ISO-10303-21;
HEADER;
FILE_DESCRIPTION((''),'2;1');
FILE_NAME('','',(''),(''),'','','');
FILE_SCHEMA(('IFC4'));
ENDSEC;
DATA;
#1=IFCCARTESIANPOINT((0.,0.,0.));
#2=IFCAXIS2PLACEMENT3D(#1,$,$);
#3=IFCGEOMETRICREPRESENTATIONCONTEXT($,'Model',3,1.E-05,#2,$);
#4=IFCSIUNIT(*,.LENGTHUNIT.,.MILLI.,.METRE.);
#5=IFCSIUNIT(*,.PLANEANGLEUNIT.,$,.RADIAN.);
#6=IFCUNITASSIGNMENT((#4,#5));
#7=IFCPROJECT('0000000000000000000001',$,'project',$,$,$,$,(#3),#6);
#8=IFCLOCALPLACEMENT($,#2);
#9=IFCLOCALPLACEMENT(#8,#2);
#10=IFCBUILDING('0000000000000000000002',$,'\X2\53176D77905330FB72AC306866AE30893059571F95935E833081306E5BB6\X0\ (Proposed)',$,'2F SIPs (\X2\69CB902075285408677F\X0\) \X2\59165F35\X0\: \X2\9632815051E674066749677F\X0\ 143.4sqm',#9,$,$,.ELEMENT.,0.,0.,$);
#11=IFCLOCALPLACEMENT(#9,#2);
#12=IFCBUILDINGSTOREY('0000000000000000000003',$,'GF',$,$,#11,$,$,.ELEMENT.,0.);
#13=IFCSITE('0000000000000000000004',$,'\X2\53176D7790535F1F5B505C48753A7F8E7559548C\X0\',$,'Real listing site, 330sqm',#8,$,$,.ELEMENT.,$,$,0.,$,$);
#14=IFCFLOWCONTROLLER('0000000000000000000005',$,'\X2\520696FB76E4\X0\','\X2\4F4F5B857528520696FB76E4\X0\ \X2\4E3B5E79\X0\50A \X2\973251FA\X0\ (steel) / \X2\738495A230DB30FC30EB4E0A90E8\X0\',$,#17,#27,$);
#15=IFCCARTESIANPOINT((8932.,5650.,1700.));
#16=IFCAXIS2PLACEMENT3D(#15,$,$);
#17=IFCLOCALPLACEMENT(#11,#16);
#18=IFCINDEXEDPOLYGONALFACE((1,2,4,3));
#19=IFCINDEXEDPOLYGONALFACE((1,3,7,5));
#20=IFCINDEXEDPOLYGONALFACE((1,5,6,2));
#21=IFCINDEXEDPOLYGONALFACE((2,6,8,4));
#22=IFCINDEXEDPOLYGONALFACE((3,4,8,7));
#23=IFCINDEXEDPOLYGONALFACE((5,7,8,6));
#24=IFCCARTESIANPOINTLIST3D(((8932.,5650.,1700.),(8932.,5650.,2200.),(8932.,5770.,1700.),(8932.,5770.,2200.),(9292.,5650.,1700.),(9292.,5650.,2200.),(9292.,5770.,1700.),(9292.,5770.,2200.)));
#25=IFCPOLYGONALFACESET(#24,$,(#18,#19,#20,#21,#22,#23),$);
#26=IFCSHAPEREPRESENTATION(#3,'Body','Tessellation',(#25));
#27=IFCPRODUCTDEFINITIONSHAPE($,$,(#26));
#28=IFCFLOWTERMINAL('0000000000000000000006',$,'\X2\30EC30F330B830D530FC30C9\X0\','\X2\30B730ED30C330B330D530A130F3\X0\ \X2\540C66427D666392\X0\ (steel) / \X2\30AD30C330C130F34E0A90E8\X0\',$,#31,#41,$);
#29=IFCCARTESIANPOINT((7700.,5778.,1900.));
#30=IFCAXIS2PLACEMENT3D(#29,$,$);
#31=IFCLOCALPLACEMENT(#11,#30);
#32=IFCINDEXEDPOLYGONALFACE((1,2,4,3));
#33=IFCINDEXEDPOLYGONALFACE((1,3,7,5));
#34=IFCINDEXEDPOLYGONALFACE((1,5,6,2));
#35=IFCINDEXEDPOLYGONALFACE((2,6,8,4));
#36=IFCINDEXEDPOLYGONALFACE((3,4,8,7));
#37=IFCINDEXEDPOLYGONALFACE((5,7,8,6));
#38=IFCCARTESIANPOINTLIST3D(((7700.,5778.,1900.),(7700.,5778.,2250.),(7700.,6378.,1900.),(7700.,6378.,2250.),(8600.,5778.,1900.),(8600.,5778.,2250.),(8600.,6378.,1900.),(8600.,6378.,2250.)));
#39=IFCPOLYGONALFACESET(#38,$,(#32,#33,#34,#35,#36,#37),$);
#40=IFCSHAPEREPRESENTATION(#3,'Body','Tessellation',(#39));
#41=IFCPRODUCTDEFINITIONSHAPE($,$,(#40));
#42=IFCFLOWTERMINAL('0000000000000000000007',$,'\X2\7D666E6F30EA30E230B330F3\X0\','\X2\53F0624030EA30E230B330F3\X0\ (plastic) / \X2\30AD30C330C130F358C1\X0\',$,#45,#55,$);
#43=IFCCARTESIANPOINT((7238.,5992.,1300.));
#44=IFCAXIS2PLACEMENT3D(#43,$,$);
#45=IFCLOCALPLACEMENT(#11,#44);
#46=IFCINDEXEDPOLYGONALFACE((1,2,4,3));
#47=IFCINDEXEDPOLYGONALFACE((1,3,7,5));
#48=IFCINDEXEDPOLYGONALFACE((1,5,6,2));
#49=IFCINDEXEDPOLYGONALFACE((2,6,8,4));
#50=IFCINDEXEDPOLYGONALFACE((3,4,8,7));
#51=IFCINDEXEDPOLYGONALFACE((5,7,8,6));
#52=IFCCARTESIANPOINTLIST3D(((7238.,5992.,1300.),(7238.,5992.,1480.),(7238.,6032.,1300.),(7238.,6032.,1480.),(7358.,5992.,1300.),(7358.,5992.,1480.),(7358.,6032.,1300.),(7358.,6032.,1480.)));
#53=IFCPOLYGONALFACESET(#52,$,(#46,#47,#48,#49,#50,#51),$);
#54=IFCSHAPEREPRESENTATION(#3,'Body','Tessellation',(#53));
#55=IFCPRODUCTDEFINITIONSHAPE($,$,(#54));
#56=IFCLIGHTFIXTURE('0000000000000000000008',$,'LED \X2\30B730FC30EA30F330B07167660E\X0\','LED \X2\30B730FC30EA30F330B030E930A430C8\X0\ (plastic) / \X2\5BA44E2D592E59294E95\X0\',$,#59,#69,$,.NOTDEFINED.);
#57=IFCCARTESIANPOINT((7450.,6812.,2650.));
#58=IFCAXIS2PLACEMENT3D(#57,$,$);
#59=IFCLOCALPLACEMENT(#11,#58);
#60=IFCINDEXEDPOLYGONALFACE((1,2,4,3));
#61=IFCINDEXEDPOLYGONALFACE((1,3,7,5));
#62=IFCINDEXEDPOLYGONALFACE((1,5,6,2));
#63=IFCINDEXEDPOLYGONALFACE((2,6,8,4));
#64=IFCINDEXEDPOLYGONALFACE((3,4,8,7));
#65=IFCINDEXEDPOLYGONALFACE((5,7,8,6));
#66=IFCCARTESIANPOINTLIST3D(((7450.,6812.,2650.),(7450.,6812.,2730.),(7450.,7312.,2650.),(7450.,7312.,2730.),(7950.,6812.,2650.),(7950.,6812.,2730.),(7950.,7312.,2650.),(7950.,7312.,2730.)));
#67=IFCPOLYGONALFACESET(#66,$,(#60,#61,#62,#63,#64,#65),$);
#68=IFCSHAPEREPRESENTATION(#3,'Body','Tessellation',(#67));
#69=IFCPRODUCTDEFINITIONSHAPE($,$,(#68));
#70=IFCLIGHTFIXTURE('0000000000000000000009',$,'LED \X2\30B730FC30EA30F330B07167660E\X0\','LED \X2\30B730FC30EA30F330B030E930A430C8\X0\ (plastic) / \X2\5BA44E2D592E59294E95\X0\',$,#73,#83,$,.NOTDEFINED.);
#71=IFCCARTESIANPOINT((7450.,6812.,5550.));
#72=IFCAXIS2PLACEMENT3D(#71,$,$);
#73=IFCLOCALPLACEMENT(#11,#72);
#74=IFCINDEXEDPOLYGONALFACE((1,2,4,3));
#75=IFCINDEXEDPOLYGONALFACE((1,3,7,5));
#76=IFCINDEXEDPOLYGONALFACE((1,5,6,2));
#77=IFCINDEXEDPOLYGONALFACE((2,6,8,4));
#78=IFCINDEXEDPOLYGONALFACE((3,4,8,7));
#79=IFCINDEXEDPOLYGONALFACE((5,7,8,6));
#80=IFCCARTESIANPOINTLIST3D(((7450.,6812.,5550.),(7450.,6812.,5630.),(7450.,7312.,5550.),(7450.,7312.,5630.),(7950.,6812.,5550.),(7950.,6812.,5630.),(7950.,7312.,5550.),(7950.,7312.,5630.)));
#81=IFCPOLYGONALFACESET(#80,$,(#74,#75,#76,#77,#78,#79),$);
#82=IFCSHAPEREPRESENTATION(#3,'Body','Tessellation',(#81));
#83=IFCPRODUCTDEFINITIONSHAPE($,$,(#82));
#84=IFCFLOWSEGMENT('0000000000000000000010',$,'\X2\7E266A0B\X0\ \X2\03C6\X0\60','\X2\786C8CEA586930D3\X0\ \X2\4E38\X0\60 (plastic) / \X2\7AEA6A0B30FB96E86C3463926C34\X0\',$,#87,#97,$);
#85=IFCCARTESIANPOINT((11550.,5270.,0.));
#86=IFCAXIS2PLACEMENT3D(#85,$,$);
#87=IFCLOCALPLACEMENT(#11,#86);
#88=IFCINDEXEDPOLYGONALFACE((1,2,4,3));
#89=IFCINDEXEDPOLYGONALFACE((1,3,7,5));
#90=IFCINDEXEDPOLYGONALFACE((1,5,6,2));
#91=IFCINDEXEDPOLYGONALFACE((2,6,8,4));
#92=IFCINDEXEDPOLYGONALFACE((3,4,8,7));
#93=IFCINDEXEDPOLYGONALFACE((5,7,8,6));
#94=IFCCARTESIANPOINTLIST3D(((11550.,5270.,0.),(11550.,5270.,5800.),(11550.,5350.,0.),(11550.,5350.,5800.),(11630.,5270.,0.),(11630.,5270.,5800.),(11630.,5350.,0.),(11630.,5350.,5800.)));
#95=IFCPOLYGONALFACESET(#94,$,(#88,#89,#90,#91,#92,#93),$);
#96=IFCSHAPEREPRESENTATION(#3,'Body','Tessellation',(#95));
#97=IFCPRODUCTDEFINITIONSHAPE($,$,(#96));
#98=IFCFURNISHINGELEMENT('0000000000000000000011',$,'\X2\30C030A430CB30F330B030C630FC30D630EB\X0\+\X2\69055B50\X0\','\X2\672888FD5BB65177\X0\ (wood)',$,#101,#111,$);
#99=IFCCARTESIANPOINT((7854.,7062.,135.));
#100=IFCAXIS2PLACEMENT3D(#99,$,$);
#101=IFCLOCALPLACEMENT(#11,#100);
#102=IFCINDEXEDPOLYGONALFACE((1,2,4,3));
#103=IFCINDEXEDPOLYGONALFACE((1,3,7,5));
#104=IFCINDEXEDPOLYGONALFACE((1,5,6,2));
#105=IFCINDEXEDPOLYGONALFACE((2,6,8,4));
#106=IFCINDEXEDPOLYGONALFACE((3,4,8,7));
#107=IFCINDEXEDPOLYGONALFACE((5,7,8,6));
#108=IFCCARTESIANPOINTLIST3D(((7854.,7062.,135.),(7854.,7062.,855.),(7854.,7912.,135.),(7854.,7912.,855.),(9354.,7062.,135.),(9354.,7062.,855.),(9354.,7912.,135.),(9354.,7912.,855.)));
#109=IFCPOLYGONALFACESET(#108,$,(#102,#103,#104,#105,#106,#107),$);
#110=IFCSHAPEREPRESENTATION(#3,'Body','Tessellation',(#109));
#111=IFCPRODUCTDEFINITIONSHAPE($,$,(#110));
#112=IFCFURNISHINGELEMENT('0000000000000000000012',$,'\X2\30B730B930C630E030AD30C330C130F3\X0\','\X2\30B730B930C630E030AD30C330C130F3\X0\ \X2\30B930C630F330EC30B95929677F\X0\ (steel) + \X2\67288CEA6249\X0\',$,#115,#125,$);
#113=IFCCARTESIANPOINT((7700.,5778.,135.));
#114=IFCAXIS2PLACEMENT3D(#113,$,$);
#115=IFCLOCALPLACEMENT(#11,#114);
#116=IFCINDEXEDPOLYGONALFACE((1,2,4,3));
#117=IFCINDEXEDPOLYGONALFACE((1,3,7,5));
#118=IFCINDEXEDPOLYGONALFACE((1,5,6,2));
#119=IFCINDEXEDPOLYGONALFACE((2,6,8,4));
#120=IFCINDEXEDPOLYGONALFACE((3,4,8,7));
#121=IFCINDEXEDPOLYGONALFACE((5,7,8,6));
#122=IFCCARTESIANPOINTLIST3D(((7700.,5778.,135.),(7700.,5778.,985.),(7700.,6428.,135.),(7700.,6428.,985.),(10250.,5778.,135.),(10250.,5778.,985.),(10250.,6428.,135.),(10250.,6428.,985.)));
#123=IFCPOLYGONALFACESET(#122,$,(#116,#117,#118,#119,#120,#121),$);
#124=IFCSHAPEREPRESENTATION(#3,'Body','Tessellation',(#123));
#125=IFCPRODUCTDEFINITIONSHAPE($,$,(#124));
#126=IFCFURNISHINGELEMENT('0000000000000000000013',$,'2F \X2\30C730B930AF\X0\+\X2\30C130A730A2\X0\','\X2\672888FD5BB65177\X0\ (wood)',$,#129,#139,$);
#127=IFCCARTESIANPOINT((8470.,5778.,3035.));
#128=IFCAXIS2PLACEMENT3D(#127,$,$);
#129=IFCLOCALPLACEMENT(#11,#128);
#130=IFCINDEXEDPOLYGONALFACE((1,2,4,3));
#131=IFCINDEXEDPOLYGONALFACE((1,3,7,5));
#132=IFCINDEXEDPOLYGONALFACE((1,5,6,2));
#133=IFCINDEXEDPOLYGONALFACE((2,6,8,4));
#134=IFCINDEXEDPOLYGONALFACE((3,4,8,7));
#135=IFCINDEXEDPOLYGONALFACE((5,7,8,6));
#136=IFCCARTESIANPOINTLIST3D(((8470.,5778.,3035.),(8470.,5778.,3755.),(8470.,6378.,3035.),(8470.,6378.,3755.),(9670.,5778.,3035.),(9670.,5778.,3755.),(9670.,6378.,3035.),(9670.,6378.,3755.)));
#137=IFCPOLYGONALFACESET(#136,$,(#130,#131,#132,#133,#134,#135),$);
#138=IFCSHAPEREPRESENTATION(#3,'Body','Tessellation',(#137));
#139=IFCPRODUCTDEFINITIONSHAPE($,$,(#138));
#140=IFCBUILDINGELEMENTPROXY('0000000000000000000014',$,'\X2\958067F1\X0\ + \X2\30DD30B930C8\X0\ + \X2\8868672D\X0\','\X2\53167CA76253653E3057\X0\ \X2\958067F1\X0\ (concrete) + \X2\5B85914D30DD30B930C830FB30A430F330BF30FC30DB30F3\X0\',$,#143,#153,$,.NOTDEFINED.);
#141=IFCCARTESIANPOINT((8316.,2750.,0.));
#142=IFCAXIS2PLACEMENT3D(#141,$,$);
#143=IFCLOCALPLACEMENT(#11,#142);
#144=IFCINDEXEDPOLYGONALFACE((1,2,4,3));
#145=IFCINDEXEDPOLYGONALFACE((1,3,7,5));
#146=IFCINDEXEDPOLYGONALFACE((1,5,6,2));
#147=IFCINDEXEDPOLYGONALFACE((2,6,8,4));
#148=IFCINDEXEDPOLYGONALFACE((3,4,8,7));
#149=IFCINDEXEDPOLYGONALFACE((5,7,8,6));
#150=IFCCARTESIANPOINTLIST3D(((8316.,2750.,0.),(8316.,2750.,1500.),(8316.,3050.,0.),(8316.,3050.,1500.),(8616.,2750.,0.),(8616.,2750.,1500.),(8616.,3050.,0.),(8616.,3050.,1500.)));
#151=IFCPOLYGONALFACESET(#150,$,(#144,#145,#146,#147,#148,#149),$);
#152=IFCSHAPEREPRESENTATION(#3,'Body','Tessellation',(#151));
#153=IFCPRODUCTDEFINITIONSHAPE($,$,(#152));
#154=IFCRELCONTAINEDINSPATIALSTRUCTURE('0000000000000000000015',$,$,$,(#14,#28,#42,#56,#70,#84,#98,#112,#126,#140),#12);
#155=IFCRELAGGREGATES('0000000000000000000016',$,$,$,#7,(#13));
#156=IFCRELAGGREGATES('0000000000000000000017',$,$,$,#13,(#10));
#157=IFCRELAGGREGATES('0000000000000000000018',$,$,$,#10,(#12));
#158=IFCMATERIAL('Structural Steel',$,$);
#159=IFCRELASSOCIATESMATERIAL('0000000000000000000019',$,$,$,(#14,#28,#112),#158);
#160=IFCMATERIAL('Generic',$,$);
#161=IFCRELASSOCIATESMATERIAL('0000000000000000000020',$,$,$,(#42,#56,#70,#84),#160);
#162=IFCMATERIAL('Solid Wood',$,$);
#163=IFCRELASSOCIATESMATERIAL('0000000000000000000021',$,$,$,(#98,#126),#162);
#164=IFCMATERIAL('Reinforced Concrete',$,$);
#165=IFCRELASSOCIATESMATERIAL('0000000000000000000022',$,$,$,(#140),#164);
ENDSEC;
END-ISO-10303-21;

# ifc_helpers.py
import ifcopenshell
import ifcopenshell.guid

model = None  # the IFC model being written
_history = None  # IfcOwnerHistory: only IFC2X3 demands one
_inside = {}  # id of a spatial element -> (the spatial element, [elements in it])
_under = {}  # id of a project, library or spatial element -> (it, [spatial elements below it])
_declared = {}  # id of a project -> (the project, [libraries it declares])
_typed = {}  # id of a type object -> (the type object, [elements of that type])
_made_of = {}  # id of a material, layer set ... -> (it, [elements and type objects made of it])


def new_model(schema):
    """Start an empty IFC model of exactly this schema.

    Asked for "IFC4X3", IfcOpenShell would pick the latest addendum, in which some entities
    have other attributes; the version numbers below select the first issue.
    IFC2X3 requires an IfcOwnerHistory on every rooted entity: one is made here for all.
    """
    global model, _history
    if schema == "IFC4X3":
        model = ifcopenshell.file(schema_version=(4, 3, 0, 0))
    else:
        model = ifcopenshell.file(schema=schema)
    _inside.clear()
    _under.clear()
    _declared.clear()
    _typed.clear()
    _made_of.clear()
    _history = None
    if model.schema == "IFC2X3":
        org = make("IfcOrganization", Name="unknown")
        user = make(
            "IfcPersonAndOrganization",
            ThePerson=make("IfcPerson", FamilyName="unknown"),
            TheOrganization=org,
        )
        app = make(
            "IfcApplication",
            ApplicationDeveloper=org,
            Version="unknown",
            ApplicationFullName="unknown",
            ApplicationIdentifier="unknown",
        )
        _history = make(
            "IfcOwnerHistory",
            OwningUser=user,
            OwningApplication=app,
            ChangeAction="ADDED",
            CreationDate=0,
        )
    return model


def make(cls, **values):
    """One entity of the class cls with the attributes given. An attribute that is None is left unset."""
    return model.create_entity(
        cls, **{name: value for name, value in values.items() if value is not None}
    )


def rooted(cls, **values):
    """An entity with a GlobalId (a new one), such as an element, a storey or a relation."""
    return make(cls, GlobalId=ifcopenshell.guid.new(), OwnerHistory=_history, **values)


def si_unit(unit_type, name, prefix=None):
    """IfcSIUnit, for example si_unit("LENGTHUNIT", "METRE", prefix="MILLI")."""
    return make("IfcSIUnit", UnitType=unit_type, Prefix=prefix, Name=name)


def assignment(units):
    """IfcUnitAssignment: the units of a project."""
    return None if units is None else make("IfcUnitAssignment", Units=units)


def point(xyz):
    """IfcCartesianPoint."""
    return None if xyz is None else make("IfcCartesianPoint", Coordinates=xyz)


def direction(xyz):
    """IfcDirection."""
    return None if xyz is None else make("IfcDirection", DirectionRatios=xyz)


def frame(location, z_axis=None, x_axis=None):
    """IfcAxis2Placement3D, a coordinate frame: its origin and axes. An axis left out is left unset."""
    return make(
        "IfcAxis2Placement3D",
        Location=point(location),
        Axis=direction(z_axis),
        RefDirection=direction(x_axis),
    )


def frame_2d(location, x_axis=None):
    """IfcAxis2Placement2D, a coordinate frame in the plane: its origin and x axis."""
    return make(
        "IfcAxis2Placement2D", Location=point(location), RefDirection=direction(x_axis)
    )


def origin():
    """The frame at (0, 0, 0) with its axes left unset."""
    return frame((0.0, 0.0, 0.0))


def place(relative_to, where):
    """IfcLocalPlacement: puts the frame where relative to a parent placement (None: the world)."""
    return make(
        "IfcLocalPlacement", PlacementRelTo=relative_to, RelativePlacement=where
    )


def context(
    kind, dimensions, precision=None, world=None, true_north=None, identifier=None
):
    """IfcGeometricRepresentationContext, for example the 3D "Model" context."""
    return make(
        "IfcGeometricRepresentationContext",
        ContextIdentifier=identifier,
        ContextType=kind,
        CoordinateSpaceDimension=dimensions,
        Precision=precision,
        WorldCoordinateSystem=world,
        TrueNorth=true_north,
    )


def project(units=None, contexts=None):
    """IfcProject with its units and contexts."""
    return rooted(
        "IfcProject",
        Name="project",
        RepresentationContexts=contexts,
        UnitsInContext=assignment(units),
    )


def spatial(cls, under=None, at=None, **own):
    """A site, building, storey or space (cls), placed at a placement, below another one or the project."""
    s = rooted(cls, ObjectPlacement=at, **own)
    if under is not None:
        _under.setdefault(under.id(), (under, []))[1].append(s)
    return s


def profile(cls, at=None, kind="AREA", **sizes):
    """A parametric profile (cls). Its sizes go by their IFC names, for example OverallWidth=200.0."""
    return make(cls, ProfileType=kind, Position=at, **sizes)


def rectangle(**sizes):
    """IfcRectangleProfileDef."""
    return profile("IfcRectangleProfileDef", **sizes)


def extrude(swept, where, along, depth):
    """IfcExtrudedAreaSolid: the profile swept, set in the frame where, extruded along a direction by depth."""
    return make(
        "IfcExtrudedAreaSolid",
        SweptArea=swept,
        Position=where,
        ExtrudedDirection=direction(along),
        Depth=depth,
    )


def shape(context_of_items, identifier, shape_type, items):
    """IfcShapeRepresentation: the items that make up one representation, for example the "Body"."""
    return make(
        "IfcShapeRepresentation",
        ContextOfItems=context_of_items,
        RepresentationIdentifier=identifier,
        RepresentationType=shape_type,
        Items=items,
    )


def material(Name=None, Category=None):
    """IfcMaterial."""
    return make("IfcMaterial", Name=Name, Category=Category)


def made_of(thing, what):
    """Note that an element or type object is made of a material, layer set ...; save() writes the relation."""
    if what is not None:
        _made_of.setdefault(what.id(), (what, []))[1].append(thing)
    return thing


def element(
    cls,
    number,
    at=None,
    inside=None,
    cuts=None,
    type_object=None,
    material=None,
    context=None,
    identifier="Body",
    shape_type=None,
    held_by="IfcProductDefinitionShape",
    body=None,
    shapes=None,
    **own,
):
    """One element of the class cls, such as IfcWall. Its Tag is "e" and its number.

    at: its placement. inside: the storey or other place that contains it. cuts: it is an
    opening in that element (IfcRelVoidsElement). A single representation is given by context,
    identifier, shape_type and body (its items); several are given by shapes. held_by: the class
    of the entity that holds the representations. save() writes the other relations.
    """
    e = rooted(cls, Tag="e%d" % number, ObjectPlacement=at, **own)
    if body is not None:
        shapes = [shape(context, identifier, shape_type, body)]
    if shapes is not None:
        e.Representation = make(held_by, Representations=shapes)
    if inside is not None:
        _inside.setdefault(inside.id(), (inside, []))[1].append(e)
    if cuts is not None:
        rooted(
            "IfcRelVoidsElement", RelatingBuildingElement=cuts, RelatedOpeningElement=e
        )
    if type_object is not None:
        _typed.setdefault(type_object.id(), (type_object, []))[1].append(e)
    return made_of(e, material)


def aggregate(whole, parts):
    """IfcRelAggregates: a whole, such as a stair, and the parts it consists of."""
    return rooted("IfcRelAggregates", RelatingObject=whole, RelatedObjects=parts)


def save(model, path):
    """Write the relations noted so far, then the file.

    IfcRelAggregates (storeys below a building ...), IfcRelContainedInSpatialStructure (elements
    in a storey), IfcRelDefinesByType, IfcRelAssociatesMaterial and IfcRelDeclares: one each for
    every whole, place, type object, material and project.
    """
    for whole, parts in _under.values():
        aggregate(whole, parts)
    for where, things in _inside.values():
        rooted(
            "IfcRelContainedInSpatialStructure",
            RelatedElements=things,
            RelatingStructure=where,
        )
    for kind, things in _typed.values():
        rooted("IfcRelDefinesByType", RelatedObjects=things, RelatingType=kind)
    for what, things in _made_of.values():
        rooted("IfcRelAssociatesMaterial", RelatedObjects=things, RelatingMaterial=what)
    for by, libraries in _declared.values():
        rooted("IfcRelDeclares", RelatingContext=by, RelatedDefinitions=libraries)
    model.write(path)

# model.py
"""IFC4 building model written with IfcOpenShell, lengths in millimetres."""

from ifc_helpers import new_model, si_unit, frame, frame_2d, origin, place, context, project, spatial, rectangle, extrude, material, element, save


model = new_model("IFC4")

# Units and contexts
model_context = context("Model", 3, precision=1e-05, world=origin())
ifc_project = project(units=[si_unit("LENGTHUNIT", "METRE", prefix="MILLI"), si_unit("PLANEANGLEUNIT", "RADIAN")], contexts=[model_context])

# Site, building, storey
site_placement = place(None, origin())
site = spatial("IfcSite", under=ifc_project, at=site_placement, Name="北海道弟子屈町美留和", ObjectType="Real listing site, 330sqm", CompositionType="ELEMENT", RefElevation=0.0)
building_placement = place(site_placement, origin())
building = spatial("IfcBuilding", under=site, at=building_placement, Name="北海道・犬と暮らす土間広めの家 (Proposed)", ObjectType="2F SIPs (構造用合板) 外張: 防腐処理杉板 143.4sqm", CompositionType="ELEMENT", ElevationOfRefHeight=0.0, ElevationOfTerrain=0.0)
storey_placement = place(building_placement, origin())
storey = spatial("IfcBuildingStorey", under=building, at=storey_placement, Name="GF", CompositionType="ELEMENT", Elevation=0.0)

# Shared definitions
ifc_material_1 = material(Name="Solid Wood")

# Shared definitions
ifc_material_2 = material(Name="Reinforced Concrete")

# Flow controller
ifc_material_3 = material(Name="Structural Steel")
flow_controller_placement = place(storey_placement, frame((8932.0, 5650.0, 1700.0)))
element("IfcFlowController", 1, at=flow_controller_placement, inside=storey, material=ifc_material_3, Name="分電盤", Description="住宅用分電盤 主幹50A 露出 (steel) / 玄関ホール上部", context=model_context, shape_type="SweptSolid", body=[
    extrude(rectangle(XDim=360.0, YDim=120.0, at=frame_2d((180.0, 60.0))), frame((8932.0, 5650.0, 1700.0)), (0.0, 0.0, 1.0), 500.0),
])

# Flow terminals
flow_terminal_1_placement = place(storey_placement, frame((7700.0, 5778.0, 1900.0)))
element("IfcFlowTerminal", 2, at=flow_terminal_1_placement, inside=storey, material=ifc_material_3, Name="レンジフード", Description="シロッコファン 同時給排 (steel) / キッチン上部", context=model_context, shape_type="SweptSolid", body=[
    extrude(rectangle(XDim=900.0, YDim=600.0, at=frame_2d((450.0, 300.0))), frame((7700.0, 5778.0, 1900.0)), (0.0, 0.0, 1.0), 350.0),
])
ifc_material_4 = material(Name="Generic")
flow_terminal_2_placement = place(storey_placement, frame((7238.0, 5992.0, 1300.0)))
element("IfcFlowTerminal", 3, at=flow_terminal_2_placement, inside=storey, material=ifc_material_4, Name="給湯リモコン", Description="台所リモコン (plastic) / キッチン壁", context=model_context, shape_type="SweptSolid", body=[
    extrude(rectangle(XDim=120.0, YDim=40.0, at=frame_2d((60.0, 20.0))), frame((7238.0, 5992.0, 1300.0)), (0.0, 0.0, 1.0), 180.0),
])

# Light fixtures
light_fixture_1_placement = place(storey_placement, frame((7450.0, 6812.0, 2650.0)))
element("IfcLightFixture", 4, at=light_fixture_1_placement, inside=storey, material=ifc_material_4, Name="LED シーリング照明", Description="LED シーリングライト (plastic) / 室中央天井", PredefinedType="NOTDEFINED", context=model_context, shape_type="SweptSolid", body=[
    extrude(rectangle(XDim=500.0, YDim=500.0, at=frame_2d((250.0, 250.0))), frame((7450.0, 6812.0, 2650.0)), (0.0, 0.0, 1.0), 80.0),
])
light_fixture_2_placement = place(storey_placement, frame((7450.0, 6812.0, 5550.0)))
element("IfcLightFixture", 5, at=light_fixture_2_placement, inside=storey, material=ifc_material_4, Name="LED シーリング照明", Description="LED シーリングライト (plastic) / 室中央天井", PredefinedType="NOTDEFINED", context=model_context, shape_type="SweptSolid", body=[
    extrude(rectangle(XDim=500.0, YDim=500.0, at=frame_2d((250.0, 250.0))), frame((7450.0, 6812.0, 5550.0)), (0.0, 0.0, 1.0), 80.0),
])

# Flow segment
flow_segment_placement = place(storey_placement, frame((11550.0, 5270.0, 0.0)))
element("IfcFlowSegment", 6, at=flow_segment_placement, inside=storey, material=ifc_material_4, Name="縦樋 φ60", Description="硬質塩ビ 丸60 (plastic) / 竪樋・雨水排水", context=model_context, shape_type="SweptSolid", body=[
    extrude(rectangle(XDim=80.0, YDim=80.0, at=frame_2d((40.0, 40.0))), frame((11550.0, 5270.0, 0.0)), (0.0, 0.0, 1.0), 5800.0),
])

# Furnishing elements
furnishing_1_placement = place(storey_placement, frame((7854.0, 7062.0, 135.0)))
element("IfcFurnishingElement", 7, at=furnishing_1_placement, inside=storey, material=ifc_material_1, Name="ダイニングテーブル+椅子", Description="木製家具 (wood)", context=model_context, shape_type="SweptSolid", body=[
    extrude(rectangle(XDim=1500.0, YDim=850.0, at=frame_2d((750.0, 425.0))), frame((7854.0, 7062.0, 135.0)), (0.0, 0.0, 1.0), 720.0),
])
furnishing_2_placement = place(storey_placement, frame((7700.0, 5778.0, 135.0)))
element("IfcFurnishingElement", 8, at=furnishing_2_placement, inside=storey, material=ifc_material_3, Name="システムキッチン", Description="システムキッチン ステンレス天板 (steel) + 木質扉", context=model_context, shape_type="SweptSolid", body=[
    extrude(rectangle(XDim=2550.0, YDim=650.0, at=frame_2d((1275.0, 325.0))), frame((7700.0, 5778.0, 135.0)), (0.0, 0.0, 1.0), 850.0),
])
furnishing_3_placement = place(storey_placement, frame((8470.0, 5778.0, 3035.0)))
element("IfcFurnishingElement", 9, at=furnishing_3_placement, inside=storey, material=ifc_material_1, Name="2F デスク+チェア", Description="木製家具 (wood)", context=model_context, shape_type="SweptSolid", body=[
    extrude(rectangle(XDim=1200.0, YDim=600.0, at=frame_2d((600.0, 300.0))), frame((8470.0, 5778.0, 3035.0)), (0.0, 0.0, 1.0), 720.0),
])

# Building element proxy
proxy_placement = place(storey_placement, frame((8316.0, 2750.0, 0.0)))
element("IfcBuildingElementProxy", 10, at=proxy_placement, inside=storey, material=ifc_material_2, Name="門柱 + ポスト + 表札", Description="化粧打放し 門柱 (concrete) + 宅配ポスト・インターホン", PredefinedType="NOTDEFINED", context=model_context, shape_type="SweptSolid", body=[
    extrude(rectangle(XDim=300.0, YDim=300.0, at=frame_2d((150.0, 150.0))), frame((8316.0, 2750.0, 0.0)), (0.0, 0.0, 1.0), 1500.0),
])

save(model, "model.ifc")
